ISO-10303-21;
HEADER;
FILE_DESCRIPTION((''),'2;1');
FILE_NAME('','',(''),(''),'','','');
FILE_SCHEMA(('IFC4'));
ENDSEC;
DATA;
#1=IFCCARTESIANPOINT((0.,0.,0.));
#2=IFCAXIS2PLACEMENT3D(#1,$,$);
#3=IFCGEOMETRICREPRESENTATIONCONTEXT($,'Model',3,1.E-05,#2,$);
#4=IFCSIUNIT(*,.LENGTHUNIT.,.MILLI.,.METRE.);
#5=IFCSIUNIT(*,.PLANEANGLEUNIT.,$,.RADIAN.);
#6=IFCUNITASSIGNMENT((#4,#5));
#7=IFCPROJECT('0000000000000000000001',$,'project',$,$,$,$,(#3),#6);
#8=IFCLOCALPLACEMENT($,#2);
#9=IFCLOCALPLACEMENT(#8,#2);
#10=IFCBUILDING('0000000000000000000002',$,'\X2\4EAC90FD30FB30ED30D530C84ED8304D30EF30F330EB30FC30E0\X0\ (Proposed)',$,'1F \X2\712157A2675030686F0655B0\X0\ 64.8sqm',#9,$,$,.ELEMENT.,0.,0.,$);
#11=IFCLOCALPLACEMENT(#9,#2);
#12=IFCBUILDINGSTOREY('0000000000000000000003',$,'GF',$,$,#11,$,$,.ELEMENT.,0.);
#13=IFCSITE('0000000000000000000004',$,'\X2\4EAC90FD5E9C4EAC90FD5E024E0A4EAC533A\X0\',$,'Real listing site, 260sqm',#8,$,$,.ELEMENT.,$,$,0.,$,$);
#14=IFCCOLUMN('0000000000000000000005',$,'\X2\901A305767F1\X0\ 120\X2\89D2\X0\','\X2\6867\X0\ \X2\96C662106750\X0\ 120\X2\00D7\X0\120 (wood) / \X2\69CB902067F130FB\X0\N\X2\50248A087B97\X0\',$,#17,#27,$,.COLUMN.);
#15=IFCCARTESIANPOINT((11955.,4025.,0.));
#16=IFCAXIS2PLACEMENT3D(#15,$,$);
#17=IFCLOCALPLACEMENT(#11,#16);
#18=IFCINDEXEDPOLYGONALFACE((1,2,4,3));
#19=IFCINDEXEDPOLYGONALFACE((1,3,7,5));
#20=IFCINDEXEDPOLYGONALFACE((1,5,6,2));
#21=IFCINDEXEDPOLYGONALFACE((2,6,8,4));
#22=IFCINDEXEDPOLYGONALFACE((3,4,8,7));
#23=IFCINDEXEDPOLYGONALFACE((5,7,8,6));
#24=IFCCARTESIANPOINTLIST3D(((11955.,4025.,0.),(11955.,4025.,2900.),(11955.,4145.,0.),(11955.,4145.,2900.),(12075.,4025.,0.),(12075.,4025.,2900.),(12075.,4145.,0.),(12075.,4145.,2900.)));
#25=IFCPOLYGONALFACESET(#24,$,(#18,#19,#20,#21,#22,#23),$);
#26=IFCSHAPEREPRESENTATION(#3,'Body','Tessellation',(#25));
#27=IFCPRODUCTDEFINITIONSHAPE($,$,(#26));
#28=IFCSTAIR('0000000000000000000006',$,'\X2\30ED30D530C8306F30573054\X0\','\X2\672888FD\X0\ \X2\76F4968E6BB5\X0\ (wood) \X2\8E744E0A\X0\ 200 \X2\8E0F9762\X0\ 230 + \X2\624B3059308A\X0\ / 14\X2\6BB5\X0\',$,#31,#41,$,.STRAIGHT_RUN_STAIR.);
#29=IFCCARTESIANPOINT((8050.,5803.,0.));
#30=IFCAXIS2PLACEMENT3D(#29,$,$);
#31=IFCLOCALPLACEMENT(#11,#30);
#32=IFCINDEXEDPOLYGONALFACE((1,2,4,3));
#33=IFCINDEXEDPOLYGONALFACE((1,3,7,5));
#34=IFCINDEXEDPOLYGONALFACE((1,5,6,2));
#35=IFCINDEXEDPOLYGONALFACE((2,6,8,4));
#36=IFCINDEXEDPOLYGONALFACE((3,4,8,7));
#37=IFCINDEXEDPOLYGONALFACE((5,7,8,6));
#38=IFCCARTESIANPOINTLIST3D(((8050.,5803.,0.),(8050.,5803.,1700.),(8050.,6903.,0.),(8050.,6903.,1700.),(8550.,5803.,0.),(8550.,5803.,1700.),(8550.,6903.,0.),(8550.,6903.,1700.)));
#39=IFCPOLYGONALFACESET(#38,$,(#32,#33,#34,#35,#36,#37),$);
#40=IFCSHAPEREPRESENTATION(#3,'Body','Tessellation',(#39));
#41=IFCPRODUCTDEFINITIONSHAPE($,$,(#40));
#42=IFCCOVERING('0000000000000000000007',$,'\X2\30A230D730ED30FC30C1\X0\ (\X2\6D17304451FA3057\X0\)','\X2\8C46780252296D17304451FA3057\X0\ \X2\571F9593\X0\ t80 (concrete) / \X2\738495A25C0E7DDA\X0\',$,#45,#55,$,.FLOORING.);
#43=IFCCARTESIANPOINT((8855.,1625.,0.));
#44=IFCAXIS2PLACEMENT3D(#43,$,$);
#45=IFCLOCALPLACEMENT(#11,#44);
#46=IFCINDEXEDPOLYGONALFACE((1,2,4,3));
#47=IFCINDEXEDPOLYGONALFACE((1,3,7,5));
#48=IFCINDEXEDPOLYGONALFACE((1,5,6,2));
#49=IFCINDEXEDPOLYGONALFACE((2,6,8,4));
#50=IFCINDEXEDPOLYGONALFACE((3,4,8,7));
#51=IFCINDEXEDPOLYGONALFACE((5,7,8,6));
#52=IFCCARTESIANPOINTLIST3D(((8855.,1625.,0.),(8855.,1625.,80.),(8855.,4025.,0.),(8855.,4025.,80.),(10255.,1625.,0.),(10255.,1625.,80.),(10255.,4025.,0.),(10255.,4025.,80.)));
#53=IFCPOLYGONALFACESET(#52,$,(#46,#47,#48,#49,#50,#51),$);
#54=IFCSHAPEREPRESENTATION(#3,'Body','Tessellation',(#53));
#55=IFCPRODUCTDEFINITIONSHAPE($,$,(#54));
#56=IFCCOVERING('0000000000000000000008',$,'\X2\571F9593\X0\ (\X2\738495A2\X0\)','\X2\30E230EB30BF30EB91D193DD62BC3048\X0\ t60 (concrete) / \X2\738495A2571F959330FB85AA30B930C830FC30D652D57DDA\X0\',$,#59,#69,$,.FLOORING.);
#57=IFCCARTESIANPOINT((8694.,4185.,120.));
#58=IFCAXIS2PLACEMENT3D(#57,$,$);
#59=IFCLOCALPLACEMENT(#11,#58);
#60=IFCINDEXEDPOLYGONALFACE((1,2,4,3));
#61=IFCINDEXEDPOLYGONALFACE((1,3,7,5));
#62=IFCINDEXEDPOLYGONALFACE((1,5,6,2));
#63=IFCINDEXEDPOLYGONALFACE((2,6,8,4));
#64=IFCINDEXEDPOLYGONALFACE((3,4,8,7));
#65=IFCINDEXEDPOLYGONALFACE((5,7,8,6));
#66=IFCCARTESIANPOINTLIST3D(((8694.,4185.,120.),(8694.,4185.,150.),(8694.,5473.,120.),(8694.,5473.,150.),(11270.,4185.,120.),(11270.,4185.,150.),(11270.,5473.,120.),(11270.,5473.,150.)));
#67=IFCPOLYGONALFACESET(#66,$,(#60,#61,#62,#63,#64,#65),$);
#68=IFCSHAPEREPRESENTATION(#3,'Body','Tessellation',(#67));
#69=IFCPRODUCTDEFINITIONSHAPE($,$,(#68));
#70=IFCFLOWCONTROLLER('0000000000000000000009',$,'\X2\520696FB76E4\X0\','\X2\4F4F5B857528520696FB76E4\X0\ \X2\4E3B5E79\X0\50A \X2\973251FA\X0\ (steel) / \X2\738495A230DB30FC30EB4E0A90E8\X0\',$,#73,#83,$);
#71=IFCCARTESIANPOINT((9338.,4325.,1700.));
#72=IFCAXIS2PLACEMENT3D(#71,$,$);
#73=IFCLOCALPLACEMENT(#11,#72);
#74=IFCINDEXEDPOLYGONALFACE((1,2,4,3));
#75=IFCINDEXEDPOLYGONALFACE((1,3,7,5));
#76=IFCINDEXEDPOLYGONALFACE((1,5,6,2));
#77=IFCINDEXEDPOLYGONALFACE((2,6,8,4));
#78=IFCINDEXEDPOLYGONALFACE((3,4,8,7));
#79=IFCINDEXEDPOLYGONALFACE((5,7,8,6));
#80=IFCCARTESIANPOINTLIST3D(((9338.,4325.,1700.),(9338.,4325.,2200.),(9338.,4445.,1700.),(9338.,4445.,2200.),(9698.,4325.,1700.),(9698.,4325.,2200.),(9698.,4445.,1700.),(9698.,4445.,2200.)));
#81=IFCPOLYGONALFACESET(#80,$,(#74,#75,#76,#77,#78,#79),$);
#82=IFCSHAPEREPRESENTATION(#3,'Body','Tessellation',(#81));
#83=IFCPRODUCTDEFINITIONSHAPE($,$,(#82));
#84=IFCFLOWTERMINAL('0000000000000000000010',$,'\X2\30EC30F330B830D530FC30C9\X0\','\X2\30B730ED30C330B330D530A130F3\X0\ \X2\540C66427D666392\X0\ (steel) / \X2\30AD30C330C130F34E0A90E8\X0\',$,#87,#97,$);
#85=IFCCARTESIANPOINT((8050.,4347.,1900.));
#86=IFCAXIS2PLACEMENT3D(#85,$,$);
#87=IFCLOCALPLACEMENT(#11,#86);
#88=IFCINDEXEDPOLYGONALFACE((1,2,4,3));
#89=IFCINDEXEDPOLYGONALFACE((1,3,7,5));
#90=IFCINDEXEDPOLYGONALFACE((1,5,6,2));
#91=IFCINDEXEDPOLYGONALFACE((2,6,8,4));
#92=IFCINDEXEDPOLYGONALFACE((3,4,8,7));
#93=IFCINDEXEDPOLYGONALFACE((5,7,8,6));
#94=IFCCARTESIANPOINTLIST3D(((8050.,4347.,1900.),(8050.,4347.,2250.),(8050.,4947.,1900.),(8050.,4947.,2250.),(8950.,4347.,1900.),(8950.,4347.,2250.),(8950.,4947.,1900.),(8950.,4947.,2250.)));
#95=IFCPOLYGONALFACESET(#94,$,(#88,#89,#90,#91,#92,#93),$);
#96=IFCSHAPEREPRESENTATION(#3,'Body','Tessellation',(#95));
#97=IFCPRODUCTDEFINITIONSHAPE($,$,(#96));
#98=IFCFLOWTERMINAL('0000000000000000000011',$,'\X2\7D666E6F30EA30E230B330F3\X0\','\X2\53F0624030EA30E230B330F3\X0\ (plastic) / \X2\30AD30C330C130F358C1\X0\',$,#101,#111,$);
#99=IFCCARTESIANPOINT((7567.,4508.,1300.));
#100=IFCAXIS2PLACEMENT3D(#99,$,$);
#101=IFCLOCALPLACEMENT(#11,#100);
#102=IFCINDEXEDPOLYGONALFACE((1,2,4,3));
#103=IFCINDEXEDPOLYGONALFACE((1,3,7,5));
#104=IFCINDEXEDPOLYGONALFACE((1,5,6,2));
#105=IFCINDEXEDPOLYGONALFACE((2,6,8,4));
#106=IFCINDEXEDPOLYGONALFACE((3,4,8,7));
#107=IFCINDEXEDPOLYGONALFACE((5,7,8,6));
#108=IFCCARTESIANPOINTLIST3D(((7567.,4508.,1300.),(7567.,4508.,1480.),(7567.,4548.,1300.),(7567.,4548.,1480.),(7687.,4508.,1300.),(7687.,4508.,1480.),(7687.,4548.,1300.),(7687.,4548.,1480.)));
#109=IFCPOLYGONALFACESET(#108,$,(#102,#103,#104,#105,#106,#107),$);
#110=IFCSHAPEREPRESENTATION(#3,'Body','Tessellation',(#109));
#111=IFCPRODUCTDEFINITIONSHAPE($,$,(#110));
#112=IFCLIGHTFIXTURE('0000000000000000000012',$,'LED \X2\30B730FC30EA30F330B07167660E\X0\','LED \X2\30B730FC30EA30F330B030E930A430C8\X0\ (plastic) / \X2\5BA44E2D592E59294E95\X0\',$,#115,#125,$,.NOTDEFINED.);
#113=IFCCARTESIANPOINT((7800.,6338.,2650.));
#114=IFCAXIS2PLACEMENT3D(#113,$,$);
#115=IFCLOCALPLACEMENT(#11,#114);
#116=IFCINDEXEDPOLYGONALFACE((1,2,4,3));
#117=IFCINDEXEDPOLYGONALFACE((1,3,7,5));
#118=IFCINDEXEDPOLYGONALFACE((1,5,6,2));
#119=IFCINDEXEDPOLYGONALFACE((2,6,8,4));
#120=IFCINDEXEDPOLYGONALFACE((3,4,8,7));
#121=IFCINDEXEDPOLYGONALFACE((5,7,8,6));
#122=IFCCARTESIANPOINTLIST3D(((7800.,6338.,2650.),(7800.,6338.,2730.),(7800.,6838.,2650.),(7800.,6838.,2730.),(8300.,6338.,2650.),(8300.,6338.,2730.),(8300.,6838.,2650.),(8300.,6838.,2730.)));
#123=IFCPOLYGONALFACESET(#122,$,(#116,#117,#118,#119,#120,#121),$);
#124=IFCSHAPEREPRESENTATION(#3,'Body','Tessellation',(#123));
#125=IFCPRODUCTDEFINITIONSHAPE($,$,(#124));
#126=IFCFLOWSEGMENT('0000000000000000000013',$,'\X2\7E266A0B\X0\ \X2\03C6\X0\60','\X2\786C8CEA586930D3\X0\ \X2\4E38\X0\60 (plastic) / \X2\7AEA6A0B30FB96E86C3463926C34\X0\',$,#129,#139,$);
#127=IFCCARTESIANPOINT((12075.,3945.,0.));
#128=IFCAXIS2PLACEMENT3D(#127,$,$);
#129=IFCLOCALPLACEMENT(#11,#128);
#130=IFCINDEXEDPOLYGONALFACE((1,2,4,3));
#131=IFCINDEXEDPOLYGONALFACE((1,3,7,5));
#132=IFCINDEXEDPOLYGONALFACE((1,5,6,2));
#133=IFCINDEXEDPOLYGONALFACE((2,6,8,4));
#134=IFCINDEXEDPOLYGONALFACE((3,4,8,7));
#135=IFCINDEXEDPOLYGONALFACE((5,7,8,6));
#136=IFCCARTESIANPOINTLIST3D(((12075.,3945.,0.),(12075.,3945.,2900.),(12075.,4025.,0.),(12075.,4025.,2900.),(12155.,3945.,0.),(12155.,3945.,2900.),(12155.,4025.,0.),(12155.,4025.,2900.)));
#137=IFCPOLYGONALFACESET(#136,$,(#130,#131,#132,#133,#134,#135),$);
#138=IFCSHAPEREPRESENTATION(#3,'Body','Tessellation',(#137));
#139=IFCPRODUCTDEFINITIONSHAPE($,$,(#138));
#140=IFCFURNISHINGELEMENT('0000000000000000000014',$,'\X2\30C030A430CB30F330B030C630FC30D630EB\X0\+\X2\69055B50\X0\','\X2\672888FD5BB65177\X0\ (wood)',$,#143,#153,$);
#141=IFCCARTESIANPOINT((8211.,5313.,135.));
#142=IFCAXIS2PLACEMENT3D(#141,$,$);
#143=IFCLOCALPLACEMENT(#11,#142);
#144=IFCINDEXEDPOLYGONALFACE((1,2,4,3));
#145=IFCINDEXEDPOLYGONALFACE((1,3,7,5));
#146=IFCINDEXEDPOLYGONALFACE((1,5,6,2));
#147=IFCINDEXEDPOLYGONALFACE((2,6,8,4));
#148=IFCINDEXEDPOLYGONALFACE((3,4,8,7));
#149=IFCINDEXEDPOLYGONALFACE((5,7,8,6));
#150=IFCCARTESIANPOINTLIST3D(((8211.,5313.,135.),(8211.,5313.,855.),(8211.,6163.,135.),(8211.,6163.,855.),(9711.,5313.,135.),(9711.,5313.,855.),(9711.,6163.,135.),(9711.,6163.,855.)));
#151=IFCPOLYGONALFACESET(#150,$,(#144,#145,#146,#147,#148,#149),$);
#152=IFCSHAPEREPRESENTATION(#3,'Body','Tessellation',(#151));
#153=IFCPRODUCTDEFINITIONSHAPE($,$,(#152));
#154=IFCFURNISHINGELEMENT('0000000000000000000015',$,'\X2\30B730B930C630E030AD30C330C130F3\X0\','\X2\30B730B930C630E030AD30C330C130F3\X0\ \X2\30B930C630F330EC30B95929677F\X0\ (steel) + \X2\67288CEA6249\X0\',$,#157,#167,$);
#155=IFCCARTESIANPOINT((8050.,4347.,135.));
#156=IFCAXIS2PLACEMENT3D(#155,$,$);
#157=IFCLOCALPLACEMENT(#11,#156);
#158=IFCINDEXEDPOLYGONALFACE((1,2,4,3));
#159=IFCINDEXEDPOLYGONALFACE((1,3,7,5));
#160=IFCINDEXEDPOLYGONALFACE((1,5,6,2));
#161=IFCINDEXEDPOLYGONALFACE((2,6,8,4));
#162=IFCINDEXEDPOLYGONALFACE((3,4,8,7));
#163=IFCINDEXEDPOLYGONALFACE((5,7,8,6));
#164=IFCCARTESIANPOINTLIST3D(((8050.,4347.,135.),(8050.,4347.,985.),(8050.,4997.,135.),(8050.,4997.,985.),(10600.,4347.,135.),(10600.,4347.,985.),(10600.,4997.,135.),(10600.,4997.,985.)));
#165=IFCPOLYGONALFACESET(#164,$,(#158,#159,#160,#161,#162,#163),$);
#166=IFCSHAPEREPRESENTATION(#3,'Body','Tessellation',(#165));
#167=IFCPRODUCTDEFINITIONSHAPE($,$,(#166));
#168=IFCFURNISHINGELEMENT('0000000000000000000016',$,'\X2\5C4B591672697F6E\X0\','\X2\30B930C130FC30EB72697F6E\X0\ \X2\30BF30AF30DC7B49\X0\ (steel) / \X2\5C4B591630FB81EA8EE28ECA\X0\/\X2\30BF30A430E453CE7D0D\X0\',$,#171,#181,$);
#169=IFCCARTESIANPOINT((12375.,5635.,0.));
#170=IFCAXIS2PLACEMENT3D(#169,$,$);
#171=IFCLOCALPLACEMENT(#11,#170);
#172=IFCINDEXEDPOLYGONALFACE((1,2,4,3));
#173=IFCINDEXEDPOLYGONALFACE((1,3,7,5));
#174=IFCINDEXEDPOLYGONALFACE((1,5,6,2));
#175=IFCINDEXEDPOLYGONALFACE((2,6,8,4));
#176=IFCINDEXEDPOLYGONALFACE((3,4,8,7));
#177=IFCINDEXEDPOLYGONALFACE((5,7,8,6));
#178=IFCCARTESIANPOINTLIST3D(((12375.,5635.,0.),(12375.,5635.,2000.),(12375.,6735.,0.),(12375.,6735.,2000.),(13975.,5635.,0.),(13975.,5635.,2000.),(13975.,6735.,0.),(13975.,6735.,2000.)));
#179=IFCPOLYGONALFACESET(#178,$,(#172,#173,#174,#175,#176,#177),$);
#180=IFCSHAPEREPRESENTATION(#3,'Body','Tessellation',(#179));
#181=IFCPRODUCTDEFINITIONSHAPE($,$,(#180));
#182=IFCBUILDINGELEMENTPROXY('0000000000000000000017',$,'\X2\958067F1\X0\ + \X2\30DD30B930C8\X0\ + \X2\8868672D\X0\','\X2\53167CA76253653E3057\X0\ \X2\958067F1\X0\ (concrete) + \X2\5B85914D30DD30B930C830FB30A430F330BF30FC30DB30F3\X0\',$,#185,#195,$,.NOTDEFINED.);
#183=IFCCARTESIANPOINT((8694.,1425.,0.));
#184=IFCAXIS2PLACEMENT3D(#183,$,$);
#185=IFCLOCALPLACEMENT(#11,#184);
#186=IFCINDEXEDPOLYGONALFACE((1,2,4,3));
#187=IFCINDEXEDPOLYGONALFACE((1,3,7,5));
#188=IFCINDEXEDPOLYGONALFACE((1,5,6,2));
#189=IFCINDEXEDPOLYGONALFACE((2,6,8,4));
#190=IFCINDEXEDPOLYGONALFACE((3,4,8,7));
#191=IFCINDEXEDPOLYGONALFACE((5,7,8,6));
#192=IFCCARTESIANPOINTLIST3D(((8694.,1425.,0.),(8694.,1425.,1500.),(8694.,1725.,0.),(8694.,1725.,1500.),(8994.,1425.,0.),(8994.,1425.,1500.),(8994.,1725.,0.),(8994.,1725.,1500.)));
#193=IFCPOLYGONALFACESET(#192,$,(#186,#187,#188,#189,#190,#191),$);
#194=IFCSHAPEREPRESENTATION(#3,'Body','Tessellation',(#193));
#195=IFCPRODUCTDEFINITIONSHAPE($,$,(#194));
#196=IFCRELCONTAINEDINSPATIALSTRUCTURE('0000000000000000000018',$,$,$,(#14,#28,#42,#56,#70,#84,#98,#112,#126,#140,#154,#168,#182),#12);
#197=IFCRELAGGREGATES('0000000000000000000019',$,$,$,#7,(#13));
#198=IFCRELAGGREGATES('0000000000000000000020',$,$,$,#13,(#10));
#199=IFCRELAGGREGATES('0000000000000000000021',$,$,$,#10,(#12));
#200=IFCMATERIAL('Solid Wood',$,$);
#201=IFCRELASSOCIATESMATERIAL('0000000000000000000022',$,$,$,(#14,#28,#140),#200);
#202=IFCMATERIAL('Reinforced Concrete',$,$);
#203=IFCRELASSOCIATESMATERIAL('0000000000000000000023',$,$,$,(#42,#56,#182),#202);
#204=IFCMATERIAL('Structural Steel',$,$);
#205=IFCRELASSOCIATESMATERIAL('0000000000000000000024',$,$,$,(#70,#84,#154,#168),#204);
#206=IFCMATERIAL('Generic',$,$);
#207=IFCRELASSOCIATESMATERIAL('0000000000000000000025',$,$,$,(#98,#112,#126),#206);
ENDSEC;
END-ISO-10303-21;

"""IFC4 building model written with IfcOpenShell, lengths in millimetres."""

from ifc_helpers import new_model, si_unit, frame, frame_2d, origin, place, context, project, spatial, rectangle, extrude, material, element, save


model = new_model("IFC4")

# Units and contexts
model_context = context("Model", 3, precision=1e-05, world=origin())
ifc_project = project(units=[si_unit("LENGTHUNIT", "METRE", prefix="MILLI"), si_unit("PLANEANGLEUNIT", "RADIAN")], contexts=[model_context])

# Site, building, storey
site_placement = place(None, origin())
site = spatial("IfcSite", under=ifc_project, at=site_placement, Name="京都府京都市上京区", ObjectType="Real listing site, 260sqm", CompositionType="ELEMENT", RefElevation=0.0)
building_placement = place(site_placement, origin())
building = spatial("IfcBuilding", under=site, at=building_placement, Name="京都・ロフト付きワンルーム (Proposed)", ObjectType="1F 無垢材と漆喰 64.8sqm", CompositionType="ELEMENT", ElevationOfRefHeight=0.0, ElevationOfTerrain=0.0)
storey_placement = place(building_placement, origin())
storey = spatial("IfcBuildingStorey", under=building, at=storey_placement, Name="GF", CompositionType="ELEMENT", Elevation=0.0)

# Column
ifc_material_1 = material(Name="Solid Wood")
column_1_placement = place(storey_placement, frame((11955.0, 4025.0, 0.0)))
element("IfcColumn", 1, at=column_1_placement, inside=storey, material=ifc_material_1, Name="通し柱 120角", Description="桧 集成材 120×120 (wood) / 構造柱・N値計算", PredefinedType="COLUMN", context=model_context, shape_type="SweptSolid", body=[
    extrude(rectangle(XDim=120.0, YDim=120.0, at=frame_2d((60.0, 60.0))), frame((11955.0, 4025.0, 0.0)), (0.0, 0.0, 1.0), 2900.0),
])

# Stair
stair_placement = place(storey_placement, frame((8050.0, 5803.0, 0.0)))
element("IfcStair", 2, at=stair_placement, inside=storey, material=ifc_material_1, Name="ロフトはしご", Description="木製 直階段 (wood) 蹴上 200 踏面 230 + 手すり / 14段", PredefinedType="STRAIGHT_RUN_STAIR", context=model_context, shape_type="SweptSolid", body=[
    extrude(rectangle(XDim=500.0, YDim=1100.0, at=frame_2d((250.0, 550.0))), frame((8050.0, 5803.0, 0.0)), (0.0, 0.0, 1.0), 1700.0),
])

# Coverings
ifc_material_2 = material(Name="Reinforced Concrete")
covering_1_placement = place(storey_placement, frame((8855.0, 1625.0, 0.0)))
element("IfcCovering", 3, at=covering_1_placement, inside=storey, material=ifc_material_2, Name="アプローチ (洗い出し)", Description="豆砂利洗い出し 土間 t80 (concrete) / 玄関導線", PredefinedType="FLOORING", context=model_context, shape_type="SweptSolid", body=[
    extrude(rectangle(XDim=1400.0, YDim=2400.0, at=frame_2d((700.0, 1200.0))), frame((8855.0, 1625.0, 0.0)), (0.0, 0.0, 1.0), 80.0),
])
covering_2_placement = place(storey_placement, frame((8694.0, 4185.0, 120.0)))
element("IfcCovering", 4, at=covering_2_placement, inside=storey, material=ifc_material_2, Name="土間 (玄関)", Description="モルタル金鏝押え t60 (concrete) / 玄関土間・薪ストーブ動線", PredefinedType="FLOORING", context=model_context, shape_type="SweptSolid", body=[
    extrude(rectangle(XDim=2576.0, YDim=1288.0, at=frame_2d((1288.0, 644.0))), frame((8694.0, 4185.0, 120.0)), (0.0, 0.0, 1.0), 30.0),
])

# Flow controller
ifc_material_3 = material(Name="Structural Steel")
flow_controller_placement = place(storey_placement, frame((9338.0, 4325.0, 1700.0)))
element("IfcFlowController", 5, at=flow_controller_placement, inside=storey, material=ifc_material_3, Name="分電盤", Description="住宅用分電盤 主幹50A 露出 (steel) / 玄関ホール上部", context=model_context, shape_type="SweptSolid", body=[
    extrude(rectangle(XDim=360.0, YDim=120.0, at=frame_2d((180.0, 60.0))), frame((9338.0, 4325.0, 1700.0)), (0.0, 0.0, 1.0), 500.0),
])

# Flow terminals
flow_terminal_1_placement = place(storey_placement, frame((8050.0, 4347.0, 1900.0)))
element("IfcFlowTerminal", 6, at=flow_terminal_1_placement, inside=storey, material=ifc_material_3, Name="レンジフード", Description="シロッコファン 同時給排 (steel) / キッチン上部", context=model_context, shape_type="SweptSolid", body=[
    extrude(rectangle(XDim=900.0, YDim=600.0, at=frame_2d((450.0, 300.0))), frame((8050.0, 4347.0, 1900.0)), (0.0, 0.0, 1.0), 350.0),
])
ifc_material_4 = material(Name="Generic")
flow_terminal_2_placement = place(storey_placement, frame((7567.0, 4508.0, 1300.0)))
element("IfcFlowTerminal", 7, at=flow_terminal_2_placement, inside=storey, material=ifc_material_4, Name="給湯リモコン", Description="台所リモコン (plastic) / キッチン壁", context=model_context, shape_type="SweptSolid", body=[
    extrude(rectangle(XDim=120.0, YDim=40.0, at=frame_2d((60.0, 20.0))), frame((7567.0, 4508.0, 1300.0)), (0.0, 0.0, 1.0), 180.0),
])

# Light fixture
light_fixture_placement = place(storey_placement, frame((7800.0, 6338.0, 2650.0)))
element("IfcLightFixture", 8, at=light_fixture_placement, inside=storey, material=ifc_material_4, Name="LED シーリング照明", Description="LED シーリングライト (plastic) / 室中央天井", PredefinedType="NOTDEFINED", context=model_context, shape_type="SweptSolid", body=[
    extrude(rectangle(XDim=500.0, YDim=500.0, at=frame_2d((250.0, 250.0))), frame((7800.0, 6338.0, 2650.0)), (0.0, 0.0, 1.0), 80.0),
])

# Flow segment
flow_segment_placement = place(storey_placement, frame((12075.0, 3945.0, 0.0)))
element("IfcFlowSegment", 9, at=flow_segment_placement, inside=storey, material=ifc_material_4, Name="縦樋 φ60", Description="硬質塩ビ 丸60 (plastic) / 竪樋・雨水排水", context=model_context, shape_type="SweptSolid", body=[
    extrude(rectangle(XDim=80.0, YDim=80.0, at=frame_2d((40.0, 40.0))), frame((12075.0, 3945.0, 0.0)), (0.0, 0.0, 1.0), 2900.0),
])

# Furnishing elements
furnishing_1_placement = place(storey_placement, frame((8211.0, 5313.0, 135.0)))
element("IfcFurnishingElement", 10, at=furnishing_1_placement, inside=storey, material=ifc_material_1, Name="ダイニングテーブル+椅子", Description="木製家具 (wood)", context=model_context, shape_type="SweptSolid", body=[
    extrude(rectangle(XDim=1500.0, YDim=850.0, at=frame_2d((750.0, 425.0))), frame((8211.0, 5313.0, 135.0)), (0.0, 0.0, 1.0), 720.0),
])
furnishing_2_placement = place(storey_placement, frame((8050.0, 4347.0, 135.0)))
element("IfcFurnishingElement", 11, at=furnishing_2_placement, inside=storey, material=ifc_material_3, Name="システムキッチン", Description="システムキッチン ステンレス天板 (steel) + 木質扉", context=model_context, shape_type="SweptSolid", body=[
    extrude(rectangle(XDim=2550.0, YDim=650.0, at=frame_2d((1275.0, 325.0))), frame((8050.0, 4347.0, 135.0)), (0.0, 0.0, 1.0), 850.0),
])
furnishing_3_placement = place(storey_placement, frame((12375.0, 5635.0, 0.0)))
element("IfcFurnishingElement", 12, at=furnishing_3_placement, inside=storey, material=ifc_material_3, Name="屋外物置", Description="スチール物置 タクボ等 (steel) / 屋外・自転車/タイヤ収納", context=model_context, shape_type="SweptSolid", body=[
    extrude(rectangle(XDim=1600.0, YDim=1100.0, at=frame_2d((800.0, 550.0))), frame((12375.0, 5635.0, 0.0)), (0.0, 0.0, 1.0), 2000.0),
])

# Building element proxy
proxy_placement = place(storey_placement, frame((8694.0, 1425.0, 0.0)))
element("IfcBuildingElementProxy", 13, at=proxy_placement, inside=storey, material=ifc_material_2, Name="門柱 + ポスト + 表札", Description="化粧打放し 門柱 (concrete) + 宅配ポスト・インターホン", PredefinedType="NOTDEFINED", context=model_context, shape_type="SweptSolid", body=[
    extrude(rectangle(XDim=300.0, YDim=300.0, at=frame_2d((150.0, 150.0))), frame((8694.0, 1425.0, 0.0)), (0.0, 0.0, 1.0), 1500.0),
])

save(model, "model.ifc")
